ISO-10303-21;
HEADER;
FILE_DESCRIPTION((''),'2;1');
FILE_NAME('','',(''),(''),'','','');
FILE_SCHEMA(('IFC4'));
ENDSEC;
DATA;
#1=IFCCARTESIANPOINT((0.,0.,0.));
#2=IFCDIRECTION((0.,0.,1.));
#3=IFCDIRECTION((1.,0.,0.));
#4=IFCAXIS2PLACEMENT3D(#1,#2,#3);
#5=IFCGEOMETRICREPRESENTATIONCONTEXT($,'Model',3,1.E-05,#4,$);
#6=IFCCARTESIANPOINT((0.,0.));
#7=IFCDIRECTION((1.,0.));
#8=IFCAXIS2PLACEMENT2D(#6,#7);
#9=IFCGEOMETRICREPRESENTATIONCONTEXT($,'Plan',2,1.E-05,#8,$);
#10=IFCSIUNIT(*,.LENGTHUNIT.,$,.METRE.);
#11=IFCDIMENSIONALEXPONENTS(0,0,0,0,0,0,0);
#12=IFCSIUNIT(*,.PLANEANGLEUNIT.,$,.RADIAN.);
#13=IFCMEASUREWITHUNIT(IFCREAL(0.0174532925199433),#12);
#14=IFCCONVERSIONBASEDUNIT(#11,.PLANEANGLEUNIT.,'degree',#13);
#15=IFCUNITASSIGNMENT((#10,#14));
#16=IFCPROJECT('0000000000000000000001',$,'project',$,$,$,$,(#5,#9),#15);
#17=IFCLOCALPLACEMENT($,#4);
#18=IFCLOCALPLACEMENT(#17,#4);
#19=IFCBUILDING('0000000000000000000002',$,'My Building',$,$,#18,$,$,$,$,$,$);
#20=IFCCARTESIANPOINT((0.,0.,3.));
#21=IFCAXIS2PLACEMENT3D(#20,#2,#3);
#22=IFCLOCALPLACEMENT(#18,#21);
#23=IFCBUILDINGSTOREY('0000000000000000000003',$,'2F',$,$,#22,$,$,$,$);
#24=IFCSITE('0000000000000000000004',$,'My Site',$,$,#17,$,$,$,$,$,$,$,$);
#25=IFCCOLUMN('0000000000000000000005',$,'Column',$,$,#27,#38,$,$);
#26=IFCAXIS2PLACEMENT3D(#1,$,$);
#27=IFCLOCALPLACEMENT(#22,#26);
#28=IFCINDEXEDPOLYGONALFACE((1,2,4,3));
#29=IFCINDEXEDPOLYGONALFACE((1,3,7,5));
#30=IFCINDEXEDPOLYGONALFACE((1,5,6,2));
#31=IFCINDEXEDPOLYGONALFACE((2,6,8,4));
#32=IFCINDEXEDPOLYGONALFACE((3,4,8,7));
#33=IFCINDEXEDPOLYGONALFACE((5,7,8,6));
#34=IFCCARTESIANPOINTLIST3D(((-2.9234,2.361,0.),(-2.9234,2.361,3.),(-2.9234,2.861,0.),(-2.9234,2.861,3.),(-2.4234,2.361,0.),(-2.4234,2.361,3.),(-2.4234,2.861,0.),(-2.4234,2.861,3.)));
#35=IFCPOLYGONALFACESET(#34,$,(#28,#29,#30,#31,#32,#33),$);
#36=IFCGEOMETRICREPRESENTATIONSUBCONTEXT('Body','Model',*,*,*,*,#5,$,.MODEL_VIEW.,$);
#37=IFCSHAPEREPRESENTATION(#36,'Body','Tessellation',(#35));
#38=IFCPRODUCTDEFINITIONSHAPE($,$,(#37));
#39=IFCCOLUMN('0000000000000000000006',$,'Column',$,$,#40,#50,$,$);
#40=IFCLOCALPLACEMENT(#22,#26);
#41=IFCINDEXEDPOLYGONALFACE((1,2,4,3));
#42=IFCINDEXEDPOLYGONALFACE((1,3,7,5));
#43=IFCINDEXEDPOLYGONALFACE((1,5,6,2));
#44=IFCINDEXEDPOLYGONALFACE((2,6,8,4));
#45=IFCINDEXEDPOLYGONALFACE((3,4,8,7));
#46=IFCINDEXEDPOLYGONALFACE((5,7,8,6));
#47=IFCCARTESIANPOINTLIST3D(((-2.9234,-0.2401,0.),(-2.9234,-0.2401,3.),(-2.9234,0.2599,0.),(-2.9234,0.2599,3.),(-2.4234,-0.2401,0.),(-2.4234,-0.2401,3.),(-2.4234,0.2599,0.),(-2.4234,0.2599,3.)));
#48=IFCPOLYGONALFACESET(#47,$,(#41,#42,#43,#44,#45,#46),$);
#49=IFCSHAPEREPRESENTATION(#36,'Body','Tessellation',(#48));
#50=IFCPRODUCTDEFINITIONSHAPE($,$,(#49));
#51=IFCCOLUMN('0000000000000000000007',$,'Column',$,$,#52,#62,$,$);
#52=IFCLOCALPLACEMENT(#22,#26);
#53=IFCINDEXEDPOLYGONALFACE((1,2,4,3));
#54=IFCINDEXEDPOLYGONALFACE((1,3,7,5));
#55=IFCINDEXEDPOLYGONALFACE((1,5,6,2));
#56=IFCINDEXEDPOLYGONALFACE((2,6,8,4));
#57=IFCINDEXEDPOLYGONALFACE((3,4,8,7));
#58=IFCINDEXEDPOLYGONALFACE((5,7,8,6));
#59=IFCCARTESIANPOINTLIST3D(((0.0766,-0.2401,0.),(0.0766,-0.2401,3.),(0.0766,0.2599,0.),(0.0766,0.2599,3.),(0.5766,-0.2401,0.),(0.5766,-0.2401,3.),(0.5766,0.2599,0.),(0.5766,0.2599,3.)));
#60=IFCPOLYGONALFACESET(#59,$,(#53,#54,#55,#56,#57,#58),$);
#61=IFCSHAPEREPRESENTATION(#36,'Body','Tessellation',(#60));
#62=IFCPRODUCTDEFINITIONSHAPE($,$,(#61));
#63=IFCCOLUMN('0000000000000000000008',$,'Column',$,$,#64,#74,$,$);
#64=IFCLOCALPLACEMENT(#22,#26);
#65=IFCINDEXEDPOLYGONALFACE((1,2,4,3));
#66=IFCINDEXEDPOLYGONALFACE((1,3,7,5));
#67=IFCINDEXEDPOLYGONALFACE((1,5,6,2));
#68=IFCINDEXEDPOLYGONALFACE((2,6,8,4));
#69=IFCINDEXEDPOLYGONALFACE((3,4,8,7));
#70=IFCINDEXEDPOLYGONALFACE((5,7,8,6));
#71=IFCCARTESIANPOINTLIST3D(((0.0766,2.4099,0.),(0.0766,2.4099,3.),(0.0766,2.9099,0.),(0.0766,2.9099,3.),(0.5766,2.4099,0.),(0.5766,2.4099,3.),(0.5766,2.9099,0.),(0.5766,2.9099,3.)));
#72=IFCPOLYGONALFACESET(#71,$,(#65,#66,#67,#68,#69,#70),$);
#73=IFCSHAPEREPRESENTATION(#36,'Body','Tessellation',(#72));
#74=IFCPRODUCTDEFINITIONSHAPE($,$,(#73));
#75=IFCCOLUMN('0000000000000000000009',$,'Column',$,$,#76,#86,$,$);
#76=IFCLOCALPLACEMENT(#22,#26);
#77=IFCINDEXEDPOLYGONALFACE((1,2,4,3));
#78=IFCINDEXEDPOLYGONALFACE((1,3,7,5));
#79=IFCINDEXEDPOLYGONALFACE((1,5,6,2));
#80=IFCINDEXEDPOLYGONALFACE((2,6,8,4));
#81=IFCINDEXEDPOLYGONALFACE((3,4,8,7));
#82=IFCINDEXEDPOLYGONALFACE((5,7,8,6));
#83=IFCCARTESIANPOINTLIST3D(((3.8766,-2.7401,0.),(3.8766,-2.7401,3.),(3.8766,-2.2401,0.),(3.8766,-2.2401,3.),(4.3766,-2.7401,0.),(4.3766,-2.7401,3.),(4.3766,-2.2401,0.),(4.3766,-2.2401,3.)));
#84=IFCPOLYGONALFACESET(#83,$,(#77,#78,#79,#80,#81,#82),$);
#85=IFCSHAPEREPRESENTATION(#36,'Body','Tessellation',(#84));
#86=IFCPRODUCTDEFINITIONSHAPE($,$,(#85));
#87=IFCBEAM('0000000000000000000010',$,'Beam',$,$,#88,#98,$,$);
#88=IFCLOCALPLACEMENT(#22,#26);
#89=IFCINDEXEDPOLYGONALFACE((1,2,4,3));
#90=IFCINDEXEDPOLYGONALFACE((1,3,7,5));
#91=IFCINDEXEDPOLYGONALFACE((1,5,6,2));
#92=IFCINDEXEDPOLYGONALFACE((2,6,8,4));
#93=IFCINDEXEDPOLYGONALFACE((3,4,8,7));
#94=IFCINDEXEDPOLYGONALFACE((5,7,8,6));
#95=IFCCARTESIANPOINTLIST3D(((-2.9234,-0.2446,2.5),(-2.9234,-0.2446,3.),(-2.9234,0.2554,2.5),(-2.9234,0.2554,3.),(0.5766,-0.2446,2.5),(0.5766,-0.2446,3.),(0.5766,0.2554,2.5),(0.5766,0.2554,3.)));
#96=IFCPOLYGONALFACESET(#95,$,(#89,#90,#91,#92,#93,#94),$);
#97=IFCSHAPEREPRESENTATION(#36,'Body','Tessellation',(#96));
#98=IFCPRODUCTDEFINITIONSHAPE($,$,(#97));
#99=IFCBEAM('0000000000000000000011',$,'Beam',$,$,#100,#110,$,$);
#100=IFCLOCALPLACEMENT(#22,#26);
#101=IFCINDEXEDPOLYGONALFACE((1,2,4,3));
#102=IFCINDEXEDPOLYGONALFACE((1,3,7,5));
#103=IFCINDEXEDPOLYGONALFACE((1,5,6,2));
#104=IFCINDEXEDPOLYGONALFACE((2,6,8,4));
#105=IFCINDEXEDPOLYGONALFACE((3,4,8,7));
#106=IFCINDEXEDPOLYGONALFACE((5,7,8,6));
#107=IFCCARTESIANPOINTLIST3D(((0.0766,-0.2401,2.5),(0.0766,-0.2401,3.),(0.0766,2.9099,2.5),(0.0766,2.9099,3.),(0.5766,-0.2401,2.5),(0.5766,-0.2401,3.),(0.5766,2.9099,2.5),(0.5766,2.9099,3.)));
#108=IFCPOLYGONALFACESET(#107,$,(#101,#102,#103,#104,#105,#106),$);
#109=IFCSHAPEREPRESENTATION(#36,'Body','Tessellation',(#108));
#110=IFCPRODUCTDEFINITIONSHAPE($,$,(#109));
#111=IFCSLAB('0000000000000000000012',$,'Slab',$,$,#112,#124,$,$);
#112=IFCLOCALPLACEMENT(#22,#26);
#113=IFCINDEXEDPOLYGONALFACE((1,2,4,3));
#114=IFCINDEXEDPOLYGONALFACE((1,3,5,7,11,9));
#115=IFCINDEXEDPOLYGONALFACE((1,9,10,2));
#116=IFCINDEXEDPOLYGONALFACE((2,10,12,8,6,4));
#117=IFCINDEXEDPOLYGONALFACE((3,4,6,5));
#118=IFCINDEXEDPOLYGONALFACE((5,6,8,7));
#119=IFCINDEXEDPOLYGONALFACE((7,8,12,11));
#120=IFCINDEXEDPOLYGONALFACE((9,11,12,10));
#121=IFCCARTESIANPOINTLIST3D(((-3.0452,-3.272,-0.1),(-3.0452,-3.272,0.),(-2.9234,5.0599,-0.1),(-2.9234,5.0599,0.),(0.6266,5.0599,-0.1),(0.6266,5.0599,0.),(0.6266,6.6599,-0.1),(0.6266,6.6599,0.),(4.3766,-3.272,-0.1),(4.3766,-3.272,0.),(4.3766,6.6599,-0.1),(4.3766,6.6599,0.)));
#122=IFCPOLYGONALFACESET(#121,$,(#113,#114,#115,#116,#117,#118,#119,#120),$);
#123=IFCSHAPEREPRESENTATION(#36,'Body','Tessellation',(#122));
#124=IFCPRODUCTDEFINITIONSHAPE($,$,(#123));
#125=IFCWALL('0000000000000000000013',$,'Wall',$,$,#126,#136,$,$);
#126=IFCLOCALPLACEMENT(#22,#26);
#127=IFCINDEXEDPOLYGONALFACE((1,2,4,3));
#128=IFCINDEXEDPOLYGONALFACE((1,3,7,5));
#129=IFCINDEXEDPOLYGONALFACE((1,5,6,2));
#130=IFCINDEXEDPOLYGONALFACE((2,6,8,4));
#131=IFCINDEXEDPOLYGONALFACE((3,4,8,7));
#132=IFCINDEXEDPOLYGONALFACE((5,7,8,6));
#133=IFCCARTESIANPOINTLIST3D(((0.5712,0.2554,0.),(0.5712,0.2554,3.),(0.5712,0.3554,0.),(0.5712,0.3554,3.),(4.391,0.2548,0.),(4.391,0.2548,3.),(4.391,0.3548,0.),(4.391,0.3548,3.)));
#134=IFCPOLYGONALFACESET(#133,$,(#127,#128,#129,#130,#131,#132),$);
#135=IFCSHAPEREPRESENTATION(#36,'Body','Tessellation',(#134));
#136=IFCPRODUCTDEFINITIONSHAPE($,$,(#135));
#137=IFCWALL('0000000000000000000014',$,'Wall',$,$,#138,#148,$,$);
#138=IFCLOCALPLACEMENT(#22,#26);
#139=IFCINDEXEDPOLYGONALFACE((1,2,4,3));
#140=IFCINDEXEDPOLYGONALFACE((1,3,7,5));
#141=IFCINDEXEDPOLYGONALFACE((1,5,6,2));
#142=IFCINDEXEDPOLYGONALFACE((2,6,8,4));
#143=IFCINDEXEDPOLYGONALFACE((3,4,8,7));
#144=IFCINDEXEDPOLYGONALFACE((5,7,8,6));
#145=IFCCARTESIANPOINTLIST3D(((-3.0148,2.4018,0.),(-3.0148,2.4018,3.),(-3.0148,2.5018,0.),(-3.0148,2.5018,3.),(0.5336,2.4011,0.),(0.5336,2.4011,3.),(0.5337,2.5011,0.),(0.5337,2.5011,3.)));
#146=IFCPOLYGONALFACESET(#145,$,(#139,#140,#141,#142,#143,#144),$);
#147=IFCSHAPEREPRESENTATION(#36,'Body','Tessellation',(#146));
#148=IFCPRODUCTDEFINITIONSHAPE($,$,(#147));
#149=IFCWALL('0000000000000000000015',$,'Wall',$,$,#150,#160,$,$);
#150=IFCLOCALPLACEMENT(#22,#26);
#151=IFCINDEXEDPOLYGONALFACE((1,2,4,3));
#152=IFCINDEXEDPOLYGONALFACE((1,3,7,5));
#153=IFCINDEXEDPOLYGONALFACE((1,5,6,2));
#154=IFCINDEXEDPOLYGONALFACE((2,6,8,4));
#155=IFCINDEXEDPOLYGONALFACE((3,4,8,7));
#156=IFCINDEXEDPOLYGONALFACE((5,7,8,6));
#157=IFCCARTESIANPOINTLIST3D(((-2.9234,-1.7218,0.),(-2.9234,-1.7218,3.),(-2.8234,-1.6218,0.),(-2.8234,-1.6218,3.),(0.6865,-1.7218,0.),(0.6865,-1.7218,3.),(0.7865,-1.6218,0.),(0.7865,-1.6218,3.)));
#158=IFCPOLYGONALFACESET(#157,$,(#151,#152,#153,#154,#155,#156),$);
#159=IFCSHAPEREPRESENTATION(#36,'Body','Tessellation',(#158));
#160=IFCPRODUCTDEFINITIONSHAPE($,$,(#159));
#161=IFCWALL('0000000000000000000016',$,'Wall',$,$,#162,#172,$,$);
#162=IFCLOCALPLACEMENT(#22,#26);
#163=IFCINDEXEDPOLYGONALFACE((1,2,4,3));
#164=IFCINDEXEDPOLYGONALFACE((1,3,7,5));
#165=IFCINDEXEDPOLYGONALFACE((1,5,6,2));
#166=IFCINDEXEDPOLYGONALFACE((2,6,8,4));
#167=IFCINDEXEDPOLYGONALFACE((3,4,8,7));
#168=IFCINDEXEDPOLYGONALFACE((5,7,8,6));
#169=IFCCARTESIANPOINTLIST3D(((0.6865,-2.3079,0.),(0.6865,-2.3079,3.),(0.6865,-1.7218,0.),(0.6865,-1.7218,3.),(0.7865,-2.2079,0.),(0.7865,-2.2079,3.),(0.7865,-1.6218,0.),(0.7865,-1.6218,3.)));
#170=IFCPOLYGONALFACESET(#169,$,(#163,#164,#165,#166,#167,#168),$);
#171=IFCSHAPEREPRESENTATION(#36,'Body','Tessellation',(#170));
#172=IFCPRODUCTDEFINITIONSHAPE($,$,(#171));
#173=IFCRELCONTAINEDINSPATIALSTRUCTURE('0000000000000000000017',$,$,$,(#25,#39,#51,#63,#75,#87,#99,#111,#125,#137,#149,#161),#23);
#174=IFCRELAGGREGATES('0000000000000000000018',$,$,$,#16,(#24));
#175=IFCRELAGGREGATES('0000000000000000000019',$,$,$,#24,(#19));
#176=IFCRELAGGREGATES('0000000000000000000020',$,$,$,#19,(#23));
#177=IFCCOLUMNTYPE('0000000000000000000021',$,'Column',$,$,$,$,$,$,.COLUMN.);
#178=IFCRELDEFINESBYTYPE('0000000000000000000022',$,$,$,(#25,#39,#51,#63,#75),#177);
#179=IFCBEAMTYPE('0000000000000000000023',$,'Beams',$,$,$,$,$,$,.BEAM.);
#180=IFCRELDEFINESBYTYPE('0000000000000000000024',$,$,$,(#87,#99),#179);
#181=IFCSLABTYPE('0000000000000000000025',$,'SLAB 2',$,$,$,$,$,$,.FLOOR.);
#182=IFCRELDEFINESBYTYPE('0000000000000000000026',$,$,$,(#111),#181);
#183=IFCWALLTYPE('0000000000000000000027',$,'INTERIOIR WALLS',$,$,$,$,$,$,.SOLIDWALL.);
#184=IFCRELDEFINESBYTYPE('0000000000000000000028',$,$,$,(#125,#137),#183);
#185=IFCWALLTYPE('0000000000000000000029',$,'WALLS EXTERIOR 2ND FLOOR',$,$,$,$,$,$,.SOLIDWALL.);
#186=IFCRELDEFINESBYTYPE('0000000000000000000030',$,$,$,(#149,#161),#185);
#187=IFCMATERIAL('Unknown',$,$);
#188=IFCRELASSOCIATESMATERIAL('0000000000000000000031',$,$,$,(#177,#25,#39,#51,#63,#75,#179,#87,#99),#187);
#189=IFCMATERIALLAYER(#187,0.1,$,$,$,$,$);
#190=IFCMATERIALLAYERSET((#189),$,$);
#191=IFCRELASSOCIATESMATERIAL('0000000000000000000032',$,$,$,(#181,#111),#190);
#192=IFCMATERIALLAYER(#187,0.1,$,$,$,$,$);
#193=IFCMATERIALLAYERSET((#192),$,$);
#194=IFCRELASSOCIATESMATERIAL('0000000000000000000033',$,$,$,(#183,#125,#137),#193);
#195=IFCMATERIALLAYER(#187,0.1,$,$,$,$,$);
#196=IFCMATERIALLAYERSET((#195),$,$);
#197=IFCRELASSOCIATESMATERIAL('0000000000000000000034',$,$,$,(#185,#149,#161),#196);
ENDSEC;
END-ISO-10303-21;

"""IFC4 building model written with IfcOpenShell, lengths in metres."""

from ifc_helpers import new_model, entity, si_unit, converted_unit, frame, origin_with_axes, origin_2d_with_axis, place, context, subcontext, project, spatial, line, indexed_curve, rectangle, outline, extrude, material, layer, layer_set, layer_usage, material_profile, profile_set, profile_usage, type_object, element, save


model = new_model("IFC4")

# Units and contexts
model_context = context("Model", 3, precision=1e-05, world=origin_with_axes())
plan_context = context("Plan", 2, precision=1e-05, world=origin_2d_with_axis())
body_context_1 = subcontext(model_context, "Body", "Model", "MODEL_VIEW")
ifc_project = project(units=[si_unit("LENGTHUNIT", "METRE"), converted_unit("PLANEANGLEUNIT", "degree", entity("IfcReal", 0.0174532925199433), si_unit("PLANEANGLEUNIT", "RADIAN"), dimensions=[0, 0, 0, 0, 0, 0, 0])], contexts=[model_context, plan_context])

# Site, building, storey
site_placement = place(None, origin_with_axes())
site = spatial("IfcSite", under=ifc_project, at=site_placement, Name="My Site")
building_placement = place(site_placement, origin_with_axes())
building = spatial("IfcBuilding", under=site, at=building_placement, Name="My Building")
storey_placement = place(building_placement, frame((0.0, 0.0, 3.0), z_axis=(0.0, 0.0, 1.0), x_axis=(1.0, 0.0, 0.0)))
storey = spatial("IfcBuildingStorey", under=building, at=storey_placement, Name="2F")

# Columns
ifc_material = material(Name="Unknown")
ifc_material_profile_1 = material_profile(ifc_material, rectangle(XDim=0.5, YDim=0.5))
ifc_profile_set_1 = profile_set([ifc_material_profile_1])
ifc_profile_usage_1 = profile_usage(ifc_profile_set_1, cardinal=5)
column_type = type_object("IfcColumnType", Name="Column", PredefinedType="COLUMN", material=ifc_profile_set_1)
column_1_placement = place(storey_placement, frame((-2.6734, 2.611, 0.0), z_axis=(0.0, 0.0, 1.0), x_axis=(1.0, 0.0, 0.0)))
element("IfcColumn", 1, at=column_1_placement, inside=storey, type_object=column_type, material=ifc_profile_usage_1, Name="Column", context=body_context_1, shape_type="SweptSolid", body=[
    extrude(rectangle(XDim=0.5, YDim=0.5), origin_with_axes(), (0.0, 0.0, 1.0), 3.0),
])
ifc_profile_usage_2 = profile_usage(ifc_profile_set_1, cardinal=5)
column_2_placement = place(storey_placement, frame((-2.6734, 0.0099, 0.0), z_axis=(0.0, 0.0, 1.0), x_axis=(1.0, 0.0, 0.0)))
element("IfcColumn", 2, at=column_2_placement, inside=storey, type_object=column_type, material=ifc_profile_usage_2, Name="Column", context=body_context_1, shape_type="SweptSolid", body=[
    extrude(rectangle(XDim=0.5, YDim=0.5), origin_with_axes(), (0.0, 0.0, 1.0), 3.0),
])
ifc_profile_usage_3 = profile_usage(ifc_profile_set_1, cardinal=5)
column_3_placement = place(storey_placement, frame((0.3266, 0.0099, 0.0), z_axis=(0.0, 0.0, 1.0), x_axis=(1.0, 0.0, 0.0)))
element("IfcColumn", 3, at=column_3_placement, inside=storey, type_object=column_type, material=ifc_profile_usage_3, Name="Column", context=body_context_1, shape_type="SweptSolid", body=[
    extrude(rectangle(XDim=0.5, YDim=0.5), origin_with_axes(), (0.0, 0.0, 1.0), 3.0),
])
ifc_profile_usage_4 = profile_usage(ifc_profile_set_1, cardinal=5)
column_4_placement = place(storey_placement, frame((0.3266, 2.6599, 0.0), z_axis=(0.0, 0.0, 1.0), x_axis=(1.0, 0.0, 0.0)))
element("IfcColumn", 4, at=column_4_placement, inside=storey, type_object=column_type, material=ifc_profile_usage_4, Name="Column", context=body_context_1, shape_type="SweptSolid", body=[
    extrude(rectangle(XDim=0.5, YDim=0.5), origin_with_axes(), (0.0, 0.0, 1.0), 3.0),
])
ifc_profile_usage_5 = profile_usage(ifc_profile_set_1, cardinal=5)
column_5_placement = place(storey_placement, frame((4.1266, -2.4901, 0.0), z_axis=(0.0, 0.0, 1.0), x_axis=(1.0, 0.0, 0.0)))
element("IfcColumn", 5, at=column_5_placement, inside=storey, type_object=column_type, material=ifc_profile_usage_5, Name="Column", context=body_context_1, shape_type="SweptSolid", body=[
    extrude(rectangle(XDim=0.5, YDim=0.5), origin_with_axes(), (0.0, 0.0, 1.0), 3.0),
])

# Beams
ifc_material_profile_2 = material_profile(ifc_material, rectangle(XDim=0.5, YDim=0.5))
ifc_profile_set_2 = profile_set([ifc_material_profile_2])
ifc_profile_usage_6 = profile_usage(ifc_profile_set_2, cardinal=7)
beam_type = type_object("IfcBeamType", Name="Beams", PredefinedType="BEAM", material=ifc_profile_set_2)
beam_1_placement = place(storey_placement, frame((-2.9234, 0.2554, 3.0), z_axis=(1.0, 0.0, 0.0), x_axis=(0.0, 1.0, 0.0)))
element("IfcBeam", 6, at=beam_1_placement, inside=storey, type_object=beam_type, material=ifc_profile_usage_6, Name="Beam", context=body_context_1, shape_type="SweptSolid", body=[
    extrude(rectangle(XDim=0.5, YDim=0.5), frame((-0.25, -0.25, 0.0), z_axis=(0.0, 0.0, 1.0), x_axis=(1.0, 0.0, 0.0)), (0.0, 0.0, 1.0), 3.5),
])
ifc_profile_usage_7 = profile_usage(ifc_profile_set_2, cardinal=7)
beam_2_placement = place(storey_placement, frame((0.0766, -0.2401, 3.0), z_axis=(0.0, 1.0, 0.0), x_axis=(-1.0, 0.0, 0.0)))
element("IfcBeam", 7, at=beam_2_placement, inside=storey, type_object=beam_type, material=ifc_profile_usage_7, Name="Beam", context=body_context_1, shape_type="SweptSolid", body=[
    extrude(rectangle(XDim=0.5, YDim=0.5), frame((-0.25, -0.25, 0.0), z_axis=(0.0, 0.0, 1.0), x_axis=(1.0, 0.0, 0.0)), (0.0, 0.0, 1.0), 3.15),
])

# Slab
ifc_layer_1 = layer(ifc_material, 0.1)
ifc_layer_set_1 = layer_set([ifc_layer_1])
ifc_layer_usage_1 = layer_usage(ifc_layer_set_1, "AXIS3", "POSITIVE", -0.1)
slab_type = type_object("IfcSlabType", Name="SLAB 2", PredefinedType="FLOOR", material=ifc_layer_set_1)
slab_placement = place(storey_placement, frame((4.3766, -3.272, 0.0), z_axis=(0.0, 0.0, 1.0), x_axis=(1.0, 0.0, 0.0)))
element("IfcSlab", 8, at=slab_placement, inside=storey, type_object=slab_type, material=ifc_layer_usage_1, Name="Slab", context=body_context_1, shape_type="SweptSolid", body=[
    extrude(outline(indexed_curve([(0.0, 0.0), (0.0, 9.9319), (-3.75, 9.9319), (-3.75, 8.3319), (-7.3, 8.3319), (-7.4218, 0.0), (0.0, 0.0)])), frame((0.0, 0.0, -0.1), z_axis=(0.0, 0.0, 1.0), x_axis=(1.0, 0.0, 0.0)), (0.0, 0.0, 1.0), 0.1),
])

# Walls
ifc_layer_2 = layer(ifc_material, 0.1)
ifc_layer_set_2 = layer_set([ifc_layer_2])
ifc_layer_usage_2 = layer_usage(ifc_layer_set_2, "AXIS2", "POSITIVE", 0.0)
wall_type_1 = type_object("IfcWallType", Name="INTERIOIR WALLS", PredefinedType="SOLIDWALL", material=ifc_layer_set_2)
wall_1_placement = place(storey_placement, frame((4.391, 0.3548, 0.0), z_axis=(0.0, 0.0, 1.0), x_axis=(-1.0, 0.000143, 0.0)))
element("IfcWall", 9, at=wall_1_placement, inside=storey, type_object=wall_type_1, material=ifc_layer_usage_2, Name="Wall", context=body_context_1, shape_type="SweptSolid", body=[
    extrude(outline(indexed_curve([(0.0, 0.0), (0.0, 0.1), (3.8198, 0.1), (3.8198, 0.0)], segments=[line(1, 2, 3, 4, 1)])), origin_with_axes(), (0.0, 0.0, 1.0), 3.0),
])
ifc_layer_usage_3 = layer_usage(ifc_layer_set_2, "AXIS2", "POSITIVE", 0.0)
wall_2_placement = place(storey_placement, frame((-3.0148, 2.4018, 0.0), z_axis=(0.0, 0.0, 1.0), x_axis=(1.0, -0.000214, 0.0)))
element("IfcWall", 10, at=wall_2_placement, inside=storey, type_object=wall_type_1, material=ifc_layer_usage_3, Name="Wall", context=body_context_1, shape_type="SweptSolid", body=[
    extrude(outline(indexed_curve([(0.0, 0.0), (0.0, 0.1), (3.5485, 0.1), (3.5485, 0.0)], segments=[line(1, 2, 3, 4, 1)])), origin_with_axes(), (0.0, 0.0, 1.0), 3.0),
])
ifc_layer_3 = layer(ifc_material, 0.1)
ifc_layer_set_3 = layer_set([ifc_layer_3])
ifc_layer_usage_4 = layer_usage(ifc_layer_set_3, "AXIS2", "POSITIVE", 0.0)
wall_type_2 = type_object("IfcWallType", Name="WALLS EXTERIOR 2ND FLOOR", PredefinedType="SOLIDWALL", material=ifc_layer_set_3)
wall_3_placement = place(storey_placement, frame((-2.9234, -1.7218, 0.0), z_axis=(0.0, 0.0, 1.0), x_axis=(1.0, 0.0, 0.0)))
element("IfcWall", 11, at=wall_3_placement, inside=storey, type_object=wall_type_2, material=ifc_layer_usage_4, Name="Wall", context=body_context_1, shape_type="SweptSolid", body=[
    extrude(outline(indexed_curve([(0.0, 0.0), (0.1, 0.1), (3.7099, 0.1), (3.6099, 0.0)], segments=[line(1, 2, 3, 4, 1)])), origin_with_axes(), (0.0, 0.0, 1.0), 3.0),
])
ifc_layer_usage_5 = layer_usage(ifc_layer_set_3, "AXIS2", "POSITIVE", 0.0)
wall_4_placement = place(storey_placement, frame((0.6865, -1.7218, 0.0), z_axis=(0.0, 0.0, 1.0), x_axis=(0.0, -1.0, 0.0)))
element("IfcWall", 12, at=wall_4_placement, inside=storey, type_object=wall_type_2, material=ifc_layer_usage_5, Name="Wall", context=body_context_1, shape_type="SweptSolid", body=[
    extrude(outline(indexed_curve([(0.0, 0.0), (-0.1, 0.1), (0.4861, 0.1), (0.5861, 0.0)], segments=[line(1, 2, 3, 4, 1)])), origin_with_axes(), (0.0, 0.0, 1.0), 3.0),
])

save(model, "model.ifc")
